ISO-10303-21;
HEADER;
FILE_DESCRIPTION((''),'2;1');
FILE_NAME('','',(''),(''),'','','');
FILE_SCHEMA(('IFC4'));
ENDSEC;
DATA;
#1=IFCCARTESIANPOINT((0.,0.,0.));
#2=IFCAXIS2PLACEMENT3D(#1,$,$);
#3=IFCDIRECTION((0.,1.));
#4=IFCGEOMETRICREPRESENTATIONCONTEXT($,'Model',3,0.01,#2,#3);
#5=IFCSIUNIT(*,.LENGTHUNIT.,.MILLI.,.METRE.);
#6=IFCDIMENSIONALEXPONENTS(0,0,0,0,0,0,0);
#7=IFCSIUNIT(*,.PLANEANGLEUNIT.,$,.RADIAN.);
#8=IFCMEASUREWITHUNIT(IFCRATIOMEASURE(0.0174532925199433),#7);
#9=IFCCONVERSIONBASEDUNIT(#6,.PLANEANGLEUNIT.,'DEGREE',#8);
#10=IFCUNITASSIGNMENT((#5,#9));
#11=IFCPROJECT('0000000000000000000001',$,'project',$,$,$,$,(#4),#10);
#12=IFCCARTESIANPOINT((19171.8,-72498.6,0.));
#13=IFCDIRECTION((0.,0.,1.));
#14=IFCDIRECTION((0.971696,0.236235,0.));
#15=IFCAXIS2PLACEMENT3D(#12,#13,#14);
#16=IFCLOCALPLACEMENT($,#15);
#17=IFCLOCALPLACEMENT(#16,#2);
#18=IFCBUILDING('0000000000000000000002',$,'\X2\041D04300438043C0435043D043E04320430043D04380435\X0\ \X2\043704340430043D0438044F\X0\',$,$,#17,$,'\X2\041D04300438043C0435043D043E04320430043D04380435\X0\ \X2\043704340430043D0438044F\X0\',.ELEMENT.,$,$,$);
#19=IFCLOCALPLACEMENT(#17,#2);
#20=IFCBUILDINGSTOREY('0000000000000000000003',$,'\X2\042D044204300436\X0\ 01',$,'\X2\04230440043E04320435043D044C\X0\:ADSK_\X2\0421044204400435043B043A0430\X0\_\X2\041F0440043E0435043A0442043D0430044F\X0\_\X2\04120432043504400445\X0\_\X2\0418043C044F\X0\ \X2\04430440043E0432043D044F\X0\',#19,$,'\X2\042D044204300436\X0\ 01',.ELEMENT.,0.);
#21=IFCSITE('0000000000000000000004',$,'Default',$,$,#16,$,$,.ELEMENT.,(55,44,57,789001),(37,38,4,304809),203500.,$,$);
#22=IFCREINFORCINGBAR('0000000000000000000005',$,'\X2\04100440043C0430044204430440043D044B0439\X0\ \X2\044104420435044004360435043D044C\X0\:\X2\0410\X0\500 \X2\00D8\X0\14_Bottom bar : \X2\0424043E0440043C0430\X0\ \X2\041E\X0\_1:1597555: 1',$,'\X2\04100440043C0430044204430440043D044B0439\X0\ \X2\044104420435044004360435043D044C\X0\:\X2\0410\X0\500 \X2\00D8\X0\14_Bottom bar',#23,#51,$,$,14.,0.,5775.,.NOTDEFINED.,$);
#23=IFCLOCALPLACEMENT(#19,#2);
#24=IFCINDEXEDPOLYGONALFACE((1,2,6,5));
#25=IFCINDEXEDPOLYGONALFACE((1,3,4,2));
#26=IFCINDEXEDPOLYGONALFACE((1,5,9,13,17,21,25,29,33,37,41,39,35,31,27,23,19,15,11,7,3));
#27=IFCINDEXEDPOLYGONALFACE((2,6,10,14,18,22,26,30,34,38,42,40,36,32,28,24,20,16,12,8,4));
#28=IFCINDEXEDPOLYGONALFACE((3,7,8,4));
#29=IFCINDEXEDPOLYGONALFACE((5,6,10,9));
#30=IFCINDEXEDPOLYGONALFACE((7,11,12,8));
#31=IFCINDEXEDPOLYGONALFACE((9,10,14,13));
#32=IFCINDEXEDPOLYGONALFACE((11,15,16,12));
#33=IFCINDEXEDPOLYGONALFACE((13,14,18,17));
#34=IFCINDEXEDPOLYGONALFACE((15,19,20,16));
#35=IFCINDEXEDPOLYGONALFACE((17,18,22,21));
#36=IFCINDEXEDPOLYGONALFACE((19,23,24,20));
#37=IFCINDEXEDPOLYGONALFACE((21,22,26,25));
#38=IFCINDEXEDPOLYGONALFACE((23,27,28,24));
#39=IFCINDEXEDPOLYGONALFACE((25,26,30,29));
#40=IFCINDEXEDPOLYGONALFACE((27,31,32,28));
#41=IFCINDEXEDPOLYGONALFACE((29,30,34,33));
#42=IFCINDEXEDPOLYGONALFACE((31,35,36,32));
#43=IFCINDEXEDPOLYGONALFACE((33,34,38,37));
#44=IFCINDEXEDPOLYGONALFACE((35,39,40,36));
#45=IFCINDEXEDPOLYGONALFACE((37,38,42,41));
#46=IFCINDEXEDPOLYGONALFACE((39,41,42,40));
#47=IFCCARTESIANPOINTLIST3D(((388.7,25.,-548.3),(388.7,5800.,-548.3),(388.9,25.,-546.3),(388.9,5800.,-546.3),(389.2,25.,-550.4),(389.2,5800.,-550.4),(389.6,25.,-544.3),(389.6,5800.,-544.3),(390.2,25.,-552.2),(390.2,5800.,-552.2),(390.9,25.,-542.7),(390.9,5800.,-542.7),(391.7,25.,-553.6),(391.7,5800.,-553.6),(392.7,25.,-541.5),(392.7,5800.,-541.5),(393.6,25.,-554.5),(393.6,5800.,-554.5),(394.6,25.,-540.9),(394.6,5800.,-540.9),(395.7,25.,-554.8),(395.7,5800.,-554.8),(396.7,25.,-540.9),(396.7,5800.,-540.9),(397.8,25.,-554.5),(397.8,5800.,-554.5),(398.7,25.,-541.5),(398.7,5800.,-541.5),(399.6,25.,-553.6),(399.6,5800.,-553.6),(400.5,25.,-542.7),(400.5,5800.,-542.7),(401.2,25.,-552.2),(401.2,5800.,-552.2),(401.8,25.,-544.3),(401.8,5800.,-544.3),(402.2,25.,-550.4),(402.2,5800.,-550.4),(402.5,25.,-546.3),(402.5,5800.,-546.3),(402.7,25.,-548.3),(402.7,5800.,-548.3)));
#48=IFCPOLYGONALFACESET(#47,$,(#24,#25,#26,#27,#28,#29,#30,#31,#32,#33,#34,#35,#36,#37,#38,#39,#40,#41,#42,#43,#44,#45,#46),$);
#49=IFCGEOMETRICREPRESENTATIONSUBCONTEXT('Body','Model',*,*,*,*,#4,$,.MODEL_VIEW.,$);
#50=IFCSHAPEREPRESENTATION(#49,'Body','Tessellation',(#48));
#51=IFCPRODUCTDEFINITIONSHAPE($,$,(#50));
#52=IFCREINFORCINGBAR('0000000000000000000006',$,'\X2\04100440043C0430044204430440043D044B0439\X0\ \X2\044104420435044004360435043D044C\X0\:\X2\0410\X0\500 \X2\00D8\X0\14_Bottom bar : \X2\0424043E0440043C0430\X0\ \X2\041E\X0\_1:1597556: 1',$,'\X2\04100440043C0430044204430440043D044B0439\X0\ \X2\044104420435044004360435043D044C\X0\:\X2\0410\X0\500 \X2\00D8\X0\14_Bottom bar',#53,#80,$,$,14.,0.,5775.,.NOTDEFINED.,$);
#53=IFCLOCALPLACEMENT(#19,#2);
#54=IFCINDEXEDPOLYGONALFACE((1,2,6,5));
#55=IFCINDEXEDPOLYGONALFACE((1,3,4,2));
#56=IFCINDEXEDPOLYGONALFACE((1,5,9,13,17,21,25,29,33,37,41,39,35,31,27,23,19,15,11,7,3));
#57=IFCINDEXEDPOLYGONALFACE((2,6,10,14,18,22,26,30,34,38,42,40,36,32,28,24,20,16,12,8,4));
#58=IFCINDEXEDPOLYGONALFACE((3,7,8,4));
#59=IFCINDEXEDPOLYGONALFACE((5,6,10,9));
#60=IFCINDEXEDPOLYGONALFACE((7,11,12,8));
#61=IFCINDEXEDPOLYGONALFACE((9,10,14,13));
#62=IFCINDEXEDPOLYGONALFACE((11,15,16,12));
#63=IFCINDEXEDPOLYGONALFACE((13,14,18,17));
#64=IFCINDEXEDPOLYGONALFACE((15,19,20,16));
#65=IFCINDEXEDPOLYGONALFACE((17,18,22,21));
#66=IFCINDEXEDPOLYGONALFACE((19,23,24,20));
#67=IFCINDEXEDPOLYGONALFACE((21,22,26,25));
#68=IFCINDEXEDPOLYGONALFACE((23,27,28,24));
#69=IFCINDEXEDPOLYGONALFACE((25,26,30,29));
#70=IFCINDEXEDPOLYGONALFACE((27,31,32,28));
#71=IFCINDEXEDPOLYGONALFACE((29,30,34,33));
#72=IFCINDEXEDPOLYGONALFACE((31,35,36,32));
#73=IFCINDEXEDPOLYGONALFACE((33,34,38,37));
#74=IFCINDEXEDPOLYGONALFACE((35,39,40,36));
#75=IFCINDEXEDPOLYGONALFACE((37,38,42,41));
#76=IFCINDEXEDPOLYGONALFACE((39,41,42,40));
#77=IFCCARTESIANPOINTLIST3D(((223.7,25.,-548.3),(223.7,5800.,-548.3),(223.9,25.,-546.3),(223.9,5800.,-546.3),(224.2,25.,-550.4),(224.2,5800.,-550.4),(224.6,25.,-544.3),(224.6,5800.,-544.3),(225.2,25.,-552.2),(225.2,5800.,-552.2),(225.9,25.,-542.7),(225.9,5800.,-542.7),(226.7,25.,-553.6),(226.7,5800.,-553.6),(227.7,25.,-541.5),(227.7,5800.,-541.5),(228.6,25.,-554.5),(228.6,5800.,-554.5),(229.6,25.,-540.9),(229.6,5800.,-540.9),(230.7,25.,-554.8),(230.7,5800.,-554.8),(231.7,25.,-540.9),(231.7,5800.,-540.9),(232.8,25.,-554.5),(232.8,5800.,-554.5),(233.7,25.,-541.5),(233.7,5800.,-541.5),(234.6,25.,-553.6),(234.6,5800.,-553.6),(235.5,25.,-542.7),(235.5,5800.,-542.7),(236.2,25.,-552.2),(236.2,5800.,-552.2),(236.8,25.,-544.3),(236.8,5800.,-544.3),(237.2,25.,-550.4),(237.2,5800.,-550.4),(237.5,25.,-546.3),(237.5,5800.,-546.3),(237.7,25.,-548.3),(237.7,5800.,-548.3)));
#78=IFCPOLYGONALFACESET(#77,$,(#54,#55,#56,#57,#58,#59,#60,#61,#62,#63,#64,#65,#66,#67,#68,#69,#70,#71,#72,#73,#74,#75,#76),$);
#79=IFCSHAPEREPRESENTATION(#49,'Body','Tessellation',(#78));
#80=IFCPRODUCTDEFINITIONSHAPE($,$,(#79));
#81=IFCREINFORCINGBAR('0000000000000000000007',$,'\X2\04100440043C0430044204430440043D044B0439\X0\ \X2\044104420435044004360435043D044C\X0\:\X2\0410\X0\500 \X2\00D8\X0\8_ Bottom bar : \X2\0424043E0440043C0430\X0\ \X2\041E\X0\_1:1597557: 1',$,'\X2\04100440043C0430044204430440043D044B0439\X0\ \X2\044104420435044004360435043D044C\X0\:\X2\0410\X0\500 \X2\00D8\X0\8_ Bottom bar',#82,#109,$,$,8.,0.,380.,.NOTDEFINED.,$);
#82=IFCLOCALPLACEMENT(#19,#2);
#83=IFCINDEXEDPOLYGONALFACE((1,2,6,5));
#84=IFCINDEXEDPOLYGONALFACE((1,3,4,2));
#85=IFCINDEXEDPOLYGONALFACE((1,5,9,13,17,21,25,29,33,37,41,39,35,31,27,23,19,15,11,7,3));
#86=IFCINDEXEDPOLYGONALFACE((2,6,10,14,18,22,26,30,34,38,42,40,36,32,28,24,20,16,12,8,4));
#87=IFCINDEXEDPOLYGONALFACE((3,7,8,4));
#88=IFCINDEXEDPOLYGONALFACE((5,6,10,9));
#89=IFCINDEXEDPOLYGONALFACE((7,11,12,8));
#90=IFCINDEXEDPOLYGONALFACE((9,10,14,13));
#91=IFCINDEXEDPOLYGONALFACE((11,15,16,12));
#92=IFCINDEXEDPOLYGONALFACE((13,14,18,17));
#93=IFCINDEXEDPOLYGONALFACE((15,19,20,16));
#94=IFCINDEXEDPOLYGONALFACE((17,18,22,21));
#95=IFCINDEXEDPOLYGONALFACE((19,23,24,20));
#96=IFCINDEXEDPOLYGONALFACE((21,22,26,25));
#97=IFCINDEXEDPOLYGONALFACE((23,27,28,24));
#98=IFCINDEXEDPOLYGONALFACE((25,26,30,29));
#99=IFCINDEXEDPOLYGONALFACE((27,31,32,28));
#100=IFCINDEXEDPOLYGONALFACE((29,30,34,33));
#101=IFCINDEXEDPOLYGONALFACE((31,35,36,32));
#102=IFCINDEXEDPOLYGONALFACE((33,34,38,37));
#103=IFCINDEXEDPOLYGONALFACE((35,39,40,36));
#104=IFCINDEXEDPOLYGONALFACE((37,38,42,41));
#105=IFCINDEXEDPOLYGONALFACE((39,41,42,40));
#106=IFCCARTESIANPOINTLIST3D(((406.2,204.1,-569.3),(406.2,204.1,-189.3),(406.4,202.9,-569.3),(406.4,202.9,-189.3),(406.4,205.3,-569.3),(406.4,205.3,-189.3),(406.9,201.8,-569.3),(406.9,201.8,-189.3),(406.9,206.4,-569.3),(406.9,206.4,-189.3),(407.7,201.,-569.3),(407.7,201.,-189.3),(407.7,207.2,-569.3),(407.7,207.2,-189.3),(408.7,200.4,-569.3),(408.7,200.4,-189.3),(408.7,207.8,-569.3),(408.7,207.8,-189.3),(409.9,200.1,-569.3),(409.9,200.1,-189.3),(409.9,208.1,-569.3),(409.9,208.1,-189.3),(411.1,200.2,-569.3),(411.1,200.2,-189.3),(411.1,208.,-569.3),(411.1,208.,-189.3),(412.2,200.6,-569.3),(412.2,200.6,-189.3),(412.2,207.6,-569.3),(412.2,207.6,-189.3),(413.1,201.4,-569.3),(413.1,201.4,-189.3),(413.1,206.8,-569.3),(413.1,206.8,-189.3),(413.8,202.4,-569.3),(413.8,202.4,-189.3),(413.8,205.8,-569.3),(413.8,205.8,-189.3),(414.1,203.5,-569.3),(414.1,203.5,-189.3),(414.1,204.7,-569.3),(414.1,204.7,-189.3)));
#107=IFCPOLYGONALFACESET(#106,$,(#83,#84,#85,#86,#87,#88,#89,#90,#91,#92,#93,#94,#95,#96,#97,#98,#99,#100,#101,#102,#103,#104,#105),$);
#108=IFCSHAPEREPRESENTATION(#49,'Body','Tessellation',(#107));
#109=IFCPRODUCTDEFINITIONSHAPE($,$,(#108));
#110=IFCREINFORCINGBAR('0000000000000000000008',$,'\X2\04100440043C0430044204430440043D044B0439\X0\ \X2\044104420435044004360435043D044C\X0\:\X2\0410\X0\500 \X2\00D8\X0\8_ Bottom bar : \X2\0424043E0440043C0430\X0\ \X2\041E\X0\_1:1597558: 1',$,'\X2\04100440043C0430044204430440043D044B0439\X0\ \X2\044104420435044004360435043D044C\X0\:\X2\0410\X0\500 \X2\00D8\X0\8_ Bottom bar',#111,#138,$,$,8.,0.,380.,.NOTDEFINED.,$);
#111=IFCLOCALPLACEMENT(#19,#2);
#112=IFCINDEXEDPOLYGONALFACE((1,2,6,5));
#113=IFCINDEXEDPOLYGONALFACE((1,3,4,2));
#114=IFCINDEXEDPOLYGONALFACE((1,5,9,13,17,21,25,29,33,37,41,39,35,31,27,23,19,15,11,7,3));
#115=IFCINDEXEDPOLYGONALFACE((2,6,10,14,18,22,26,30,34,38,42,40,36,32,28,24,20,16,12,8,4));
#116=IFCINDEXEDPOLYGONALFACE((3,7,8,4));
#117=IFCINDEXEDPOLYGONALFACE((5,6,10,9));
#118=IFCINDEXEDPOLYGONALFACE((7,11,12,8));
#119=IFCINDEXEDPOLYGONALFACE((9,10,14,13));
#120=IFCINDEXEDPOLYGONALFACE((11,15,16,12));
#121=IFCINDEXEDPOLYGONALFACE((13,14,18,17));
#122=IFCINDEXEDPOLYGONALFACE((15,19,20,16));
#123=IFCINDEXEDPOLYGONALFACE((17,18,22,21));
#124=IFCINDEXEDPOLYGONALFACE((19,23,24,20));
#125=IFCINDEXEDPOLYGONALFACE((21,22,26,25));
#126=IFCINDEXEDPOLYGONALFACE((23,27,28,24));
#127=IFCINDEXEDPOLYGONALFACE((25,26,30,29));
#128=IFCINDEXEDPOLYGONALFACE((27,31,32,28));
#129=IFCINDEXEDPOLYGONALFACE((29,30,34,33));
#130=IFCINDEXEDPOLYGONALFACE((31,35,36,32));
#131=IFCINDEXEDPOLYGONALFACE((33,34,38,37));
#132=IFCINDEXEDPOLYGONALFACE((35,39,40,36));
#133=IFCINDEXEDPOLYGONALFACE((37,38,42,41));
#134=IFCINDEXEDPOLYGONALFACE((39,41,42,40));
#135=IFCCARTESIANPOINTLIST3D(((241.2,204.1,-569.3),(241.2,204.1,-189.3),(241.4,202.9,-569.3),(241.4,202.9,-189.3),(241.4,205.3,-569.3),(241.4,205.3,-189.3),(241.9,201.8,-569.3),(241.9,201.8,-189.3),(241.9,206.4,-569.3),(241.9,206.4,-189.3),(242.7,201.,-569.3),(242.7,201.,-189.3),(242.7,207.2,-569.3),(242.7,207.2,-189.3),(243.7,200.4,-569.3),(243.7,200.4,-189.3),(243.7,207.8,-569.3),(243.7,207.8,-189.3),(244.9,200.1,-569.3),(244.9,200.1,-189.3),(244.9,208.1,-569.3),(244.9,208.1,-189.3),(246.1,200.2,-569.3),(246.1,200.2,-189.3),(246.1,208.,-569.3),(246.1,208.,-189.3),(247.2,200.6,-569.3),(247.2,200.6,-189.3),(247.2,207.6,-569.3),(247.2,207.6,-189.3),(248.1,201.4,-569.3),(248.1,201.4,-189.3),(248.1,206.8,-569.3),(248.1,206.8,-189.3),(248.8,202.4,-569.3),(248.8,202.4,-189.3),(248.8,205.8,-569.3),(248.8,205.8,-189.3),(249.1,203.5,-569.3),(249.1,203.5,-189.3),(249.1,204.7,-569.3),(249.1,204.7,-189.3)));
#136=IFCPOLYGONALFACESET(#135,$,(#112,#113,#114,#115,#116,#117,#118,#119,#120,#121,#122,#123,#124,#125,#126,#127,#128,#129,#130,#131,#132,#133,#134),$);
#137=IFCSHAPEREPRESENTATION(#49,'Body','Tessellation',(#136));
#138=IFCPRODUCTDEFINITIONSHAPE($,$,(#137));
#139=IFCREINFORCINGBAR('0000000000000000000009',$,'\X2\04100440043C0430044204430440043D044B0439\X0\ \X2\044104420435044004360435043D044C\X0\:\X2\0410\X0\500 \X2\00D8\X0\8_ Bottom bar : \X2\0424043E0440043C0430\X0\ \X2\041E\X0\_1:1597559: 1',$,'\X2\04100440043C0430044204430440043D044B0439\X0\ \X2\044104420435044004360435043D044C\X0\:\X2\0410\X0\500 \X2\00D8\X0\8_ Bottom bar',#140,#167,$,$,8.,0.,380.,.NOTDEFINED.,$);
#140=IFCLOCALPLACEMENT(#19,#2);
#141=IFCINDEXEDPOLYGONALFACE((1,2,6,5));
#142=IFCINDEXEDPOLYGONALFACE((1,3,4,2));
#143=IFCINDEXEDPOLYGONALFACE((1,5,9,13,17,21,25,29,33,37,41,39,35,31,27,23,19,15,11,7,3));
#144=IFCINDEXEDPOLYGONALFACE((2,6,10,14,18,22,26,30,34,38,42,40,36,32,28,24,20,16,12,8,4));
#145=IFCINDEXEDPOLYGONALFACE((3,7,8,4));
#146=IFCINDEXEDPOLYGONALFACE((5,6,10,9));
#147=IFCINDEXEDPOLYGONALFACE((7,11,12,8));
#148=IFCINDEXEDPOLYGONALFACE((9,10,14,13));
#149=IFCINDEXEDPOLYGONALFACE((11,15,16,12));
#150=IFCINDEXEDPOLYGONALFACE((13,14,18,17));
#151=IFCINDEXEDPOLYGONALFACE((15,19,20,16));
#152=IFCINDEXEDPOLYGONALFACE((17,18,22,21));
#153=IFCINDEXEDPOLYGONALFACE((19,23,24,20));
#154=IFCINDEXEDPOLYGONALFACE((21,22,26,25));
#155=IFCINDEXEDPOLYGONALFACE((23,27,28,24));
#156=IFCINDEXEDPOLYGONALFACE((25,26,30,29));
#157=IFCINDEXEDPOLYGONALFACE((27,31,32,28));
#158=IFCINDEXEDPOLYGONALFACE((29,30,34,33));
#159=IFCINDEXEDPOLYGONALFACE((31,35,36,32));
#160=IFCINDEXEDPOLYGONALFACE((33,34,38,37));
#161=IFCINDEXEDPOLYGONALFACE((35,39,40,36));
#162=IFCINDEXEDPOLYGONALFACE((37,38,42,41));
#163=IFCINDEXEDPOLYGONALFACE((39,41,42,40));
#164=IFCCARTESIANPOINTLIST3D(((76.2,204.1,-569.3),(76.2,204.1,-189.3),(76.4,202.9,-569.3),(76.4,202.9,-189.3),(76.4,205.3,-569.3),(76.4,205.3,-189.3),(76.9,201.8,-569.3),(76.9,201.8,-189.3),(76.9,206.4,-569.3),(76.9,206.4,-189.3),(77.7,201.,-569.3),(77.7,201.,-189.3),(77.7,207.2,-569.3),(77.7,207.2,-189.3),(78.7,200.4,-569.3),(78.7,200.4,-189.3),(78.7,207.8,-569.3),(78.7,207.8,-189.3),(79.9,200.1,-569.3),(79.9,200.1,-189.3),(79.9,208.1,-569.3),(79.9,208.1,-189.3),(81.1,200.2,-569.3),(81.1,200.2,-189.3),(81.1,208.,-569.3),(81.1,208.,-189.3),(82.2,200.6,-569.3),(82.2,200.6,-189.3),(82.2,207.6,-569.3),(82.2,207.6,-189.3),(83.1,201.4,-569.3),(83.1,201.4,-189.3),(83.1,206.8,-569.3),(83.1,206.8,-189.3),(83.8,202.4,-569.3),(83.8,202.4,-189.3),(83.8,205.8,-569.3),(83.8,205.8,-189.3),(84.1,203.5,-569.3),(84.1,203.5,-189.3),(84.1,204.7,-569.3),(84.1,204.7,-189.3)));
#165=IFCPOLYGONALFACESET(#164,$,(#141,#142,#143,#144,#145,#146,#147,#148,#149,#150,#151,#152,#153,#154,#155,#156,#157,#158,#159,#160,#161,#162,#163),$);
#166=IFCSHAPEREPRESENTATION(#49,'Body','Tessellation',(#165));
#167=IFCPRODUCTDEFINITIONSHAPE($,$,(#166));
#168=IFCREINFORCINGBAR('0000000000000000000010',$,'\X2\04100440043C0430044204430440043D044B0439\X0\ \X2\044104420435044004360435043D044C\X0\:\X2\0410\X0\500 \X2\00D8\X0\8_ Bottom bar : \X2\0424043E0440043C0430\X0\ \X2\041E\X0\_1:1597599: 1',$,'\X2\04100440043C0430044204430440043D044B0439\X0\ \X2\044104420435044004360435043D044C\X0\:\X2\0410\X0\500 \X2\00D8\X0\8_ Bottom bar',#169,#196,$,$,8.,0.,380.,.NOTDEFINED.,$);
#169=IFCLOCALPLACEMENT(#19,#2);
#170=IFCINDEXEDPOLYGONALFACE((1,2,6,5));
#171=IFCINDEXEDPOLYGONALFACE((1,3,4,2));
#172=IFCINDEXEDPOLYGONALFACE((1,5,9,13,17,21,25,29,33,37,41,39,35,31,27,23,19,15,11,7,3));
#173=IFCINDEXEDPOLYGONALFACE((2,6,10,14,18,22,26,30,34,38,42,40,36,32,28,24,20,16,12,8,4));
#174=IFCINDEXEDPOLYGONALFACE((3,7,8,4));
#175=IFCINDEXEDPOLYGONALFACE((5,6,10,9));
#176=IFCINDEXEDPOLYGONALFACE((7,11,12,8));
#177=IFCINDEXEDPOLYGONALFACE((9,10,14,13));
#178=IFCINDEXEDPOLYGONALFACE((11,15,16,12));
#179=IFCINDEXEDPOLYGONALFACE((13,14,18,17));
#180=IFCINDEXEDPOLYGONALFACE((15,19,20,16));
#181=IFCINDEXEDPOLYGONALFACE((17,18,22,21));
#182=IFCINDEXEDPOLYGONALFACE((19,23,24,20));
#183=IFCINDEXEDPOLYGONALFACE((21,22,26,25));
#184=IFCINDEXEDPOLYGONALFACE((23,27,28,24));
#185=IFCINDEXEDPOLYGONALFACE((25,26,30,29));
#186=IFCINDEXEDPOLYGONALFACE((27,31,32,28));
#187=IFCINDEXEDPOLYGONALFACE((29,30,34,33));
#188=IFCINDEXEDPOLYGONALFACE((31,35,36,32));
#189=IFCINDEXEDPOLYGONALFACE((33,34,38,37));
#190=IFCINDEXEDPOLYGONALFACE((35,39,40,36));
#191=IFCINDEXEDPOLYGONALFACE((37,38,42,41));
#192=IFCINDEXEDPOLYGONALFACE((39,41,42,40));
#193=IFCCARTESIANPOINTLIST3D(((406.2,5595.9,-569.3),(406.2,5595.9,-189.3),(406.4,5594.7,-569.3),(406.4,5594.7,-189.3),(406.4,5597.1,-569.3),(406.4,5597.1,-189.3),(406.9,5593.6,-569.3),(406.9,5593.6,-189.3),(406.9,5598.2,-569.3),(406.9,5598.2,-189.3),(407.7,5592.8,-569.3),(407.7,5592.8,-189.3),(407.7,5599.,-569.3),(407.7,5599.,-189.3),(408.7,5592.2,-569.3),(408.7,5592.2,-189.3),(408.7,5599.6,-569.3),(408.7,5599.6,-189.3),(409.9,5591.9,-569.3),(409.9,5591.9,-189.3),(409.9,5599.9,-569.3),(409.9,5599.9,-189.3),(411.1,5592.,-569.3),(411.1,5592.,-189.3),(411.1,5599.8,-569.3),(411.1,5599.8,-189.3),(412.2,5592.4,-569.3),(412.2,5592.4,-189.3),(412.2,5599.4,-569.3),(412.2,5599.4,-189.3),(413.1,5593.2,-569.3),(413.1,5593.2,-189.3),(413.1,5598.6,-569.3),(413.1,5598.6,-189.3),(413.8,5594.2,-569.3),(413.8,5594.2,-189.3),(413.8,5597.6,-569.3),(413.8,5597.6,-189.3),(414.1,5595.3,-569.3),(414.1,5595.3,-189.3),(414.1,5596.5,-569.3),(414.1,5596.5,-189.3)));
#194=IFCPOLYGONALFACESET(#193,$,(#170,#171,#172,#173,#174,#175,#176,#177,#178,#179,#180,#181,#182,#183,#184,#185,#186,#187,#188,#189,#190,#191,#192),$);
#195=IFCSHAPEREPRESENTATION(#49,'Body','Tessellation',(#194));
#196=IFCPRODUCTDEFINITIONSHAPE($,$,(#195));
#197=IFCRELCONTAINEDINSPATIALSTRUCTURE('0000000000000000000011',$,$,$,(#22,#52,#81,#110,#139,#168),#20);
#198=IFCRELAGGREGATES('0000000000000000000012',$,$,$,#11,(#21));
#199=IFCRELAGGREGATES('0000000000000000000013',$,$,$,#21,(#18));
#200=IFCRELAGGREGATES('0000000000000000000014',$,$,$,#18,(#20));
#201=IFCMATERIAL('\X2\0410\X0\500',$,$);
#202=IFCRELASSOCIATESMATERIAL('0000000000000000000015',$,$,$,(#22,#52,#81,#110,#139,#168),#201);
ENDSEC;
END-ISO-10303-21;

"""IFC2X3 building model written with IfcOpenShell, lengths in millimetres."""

from ifc_helpers import new_model, entity, si_unit, converted_unit, direction, frame, origin, place, context, subcontext, project, spatial, material, element, save


model = new_model("IFC2X3")

# Units and contexts
model_context = context("Model", 3, precision=0.01, world=origin(), true_north=direction((0.0, 1.0)))
body_context = subcontext(model_context, "Body", "Model", "MODEL_VIEW")
ifc_project = project(units=[si_unit("LENGTHUNIT", "METRE", prefix="MILLI"), converted_unit("PLANEANGLEUNIT", "DEGREE", entity("IfcRatioMeasure", 0.0174532925199433), si_unit("PLANEANGLEUNIT", "RADIAN"), dimensions=[0, 0, 0, 0, 0, 0, 0])], contexts=[model_context])

# Site, building, storey
site_placement = place(None, frame((19171.8, -72498.6, 0.0), z_axis=(0.0, 0.0, 1.0), x_axis=(0.971696, 0.236235, 0.0)))
site = spatial("IfcSite", under=ifc_project, at=site_placement, Name="Default", CompositionType="ELEMENT", RefLatitude=(55, 44, 57, 789001), RefLongitude=(37, 38, 4, 304809), RefElevation=203500.0)
building_placement = place(site_placement, origin())
building = spatial("IfcBuilding", under=site, at=building_placement, Name="Наименование здания", LongName="Наименование здания", CompositionType="ELEMENT")
storey_placement = place(building_placement, origin())
storey = spatial("IfcBuildingStorey", under=building, at=storey_placement, Name="Этаж 01", ObjectType="Уровень:ADSK_Стрелка_Проектная_Вверх_Имя уровня", LongName="Этаж 01", CompositionType="ELEMENT", Elevation=0.0)

# Reinforcing bars
ifc_material = material(Name="А500")
placement = place(storey_placement, origin())
element("IfcReinforcingBar", 1, at=placement, inside=storey, material=ifc_material, Name="Арматурный стержень:А500 Ø14_Bottom bar : Форма О_1:1597555: 1", ObjectType="Арматурный стержень:А500 Ø14_Bottom bar", BarLength=5775.0, BarRole="NOTDEFINED", CrossSectionArea=0.0, NominalDiameter=14.0, context=body_context, shape_type="AdvancedSweptSolid", body=[
    entity("IfcSweptDiskSolid", entity("IfcCompositeCurve", [entity("IfcCompositeCurveSegment", "CONTINUOUS", True, entity("IfcPolyline", [entity("IfcCartesianPoint", [395.7, 5800.0, -547.8]), entity("IfcCartesianPoint", [395.7, 25.0, -547.8])]))], False), 7.0, None, 0.0, 1.0),
])
element("IfcReinforcingBar", 2, at=placement, inside=storey, material=ifc_material, Name="Арматурный стержень:А500 Ø14_Bottom bar : Форма О_1:1597556: 1", ObjectType="Арматурный стержень:А500 Ø14_Bottom bar", BarLength=5775.0, BarRole="NOTDEFINED", CrossSectionArea=0.0, NominalDiameter=14.0, context=body_context, shape_type="AdvancedSweptSolid", body=[
    entity("IfcSweptDiskSolid", entity("IfcCompositeCurve", [entity("IfcCompositeCurveSegment", "CONTINUOUS", True, entity("IfcPolyline", [entity("IfcCartesianPoint", [230.7, 5800.0, -547.8]), entity("IfcCartesianPoint", [230.7, 25.0, -547.8])]))], False), 7.0, None, 0.0, 1.0),
])
element("IfcReinforcingBar", 3, at=placement, inside=storey, material=ifc_material, Name="Арматурный стержень:А500 Ø8_ Bottom bar : Форма О_1:1597557: 1", ObjectType="Арматурный стержень:А500 Ø8_ Bottom bar", BarLength=380.0, BarRole="NOTDEFINED", CrossSectionArea=0.0, NominalDiameter=8.0, context=body_context, shape_type="AdvancedSweptSolid", body=[
    entity("IfcSweptDiskSolid", entity("IfcCompositeCurve", [entity("IfcCompositeCurveSegment", "CONTINUOUS", True, entity("IfcPolyline", [entity("IfcCartesianPoint", [410.2, 204.1, -189.3]), entity("IfcCartesianPoint", [410.2, 204.1, -569.3])]))], False), 4.0, None, 0.0, 1.0),
])
element("IfcReinforcingBar", 4, at=placement, inside=storey, material=ifc_material, Name="Арматурный стержень:А500 Ø8_ Bottom bar : Форма О_1:1597558: 1", ObjectType="Арматурный стержень:А500 Ø8_ Bottom bar", BarLength=380.0, BarRole="NOTDEFINED", CrossSectionArea=0.0, NominalDiameter=8.0, context=body_context, shape_type="AdvancedSweptSolid", body=[
    entity("IfcSweptDiskSolid", entity("IfcCompositeCurve", [entity("IfcCompositeCurveSegment", "CONTINUOUS", True, entity("IfcPolyline", [entity("IfcCartesianPoint", [245.2, 204.1, -189.3]), entity("IfcCartesianPoint", [245.2, 204.1, -569.3])]))], False), 4.0, None, 0.0, 1.0),
])
element("IfcReinforcingBar", 5, at=placement, inside=storey, material=ifc_material, Name="Арматурный стержень:А500 Ø8_ Bottom bar : Форма О_1:1597559: 1", ObjectType="Арматурный стержень:А500 Ø8_ Bottom bar", BarLength=380.0, BarRole="NOTDEFINED", CrossSectionArea=0.0, NominalDiameter=8.0, context=body_context, shape_type="AdvancedSweptSolid", body=[
    entity("IfcSweptDiskSolid", entity("IfcCompositeCurve", [entity("IfcCompositeCurveSegment", "CONTINUOUS", True, entity("IfcPolyline", [entity("IfcCartesianPoint", [80.2, 204.1, -189.3]), entity("IfcCartesianPoint", [80.2, 204.1, -569.3])]))], False), 4.0, None, 0.0, 1.0),
])
element("IfcReinforcingBar", 6, at=placement, inside=storey, material=ifc_material, Name="Арматурный стержень:А500 Ø8_ Bottom bar : Форма О_1:1597599: 1", ObjectType="Арматурный стержень:А500 Ø8_ Bottom bar", BarLength=380.0, BarRole="NOTDEFINED", CrossSectionArea=0.0, NominalDiameter=8.0, context=body_context, shape_type="AdvancedSweptSolid", body=[
    entity("IfcSweptDiskSolid", entity("IfcCompositeCurve", [entity("IfcCompositeCurveSegment", "CONTINUOUS", True, entity("IfcPolyline", [entity("IfcCartesianPoint", [410.2, 5595.9, -189.3]), entity("IfcCartesianPoint", [410.2, 5595.9, -569.3])]))], False), 4.0, None, 0.0, 1.0),
])

save(model, "model.ifc")
